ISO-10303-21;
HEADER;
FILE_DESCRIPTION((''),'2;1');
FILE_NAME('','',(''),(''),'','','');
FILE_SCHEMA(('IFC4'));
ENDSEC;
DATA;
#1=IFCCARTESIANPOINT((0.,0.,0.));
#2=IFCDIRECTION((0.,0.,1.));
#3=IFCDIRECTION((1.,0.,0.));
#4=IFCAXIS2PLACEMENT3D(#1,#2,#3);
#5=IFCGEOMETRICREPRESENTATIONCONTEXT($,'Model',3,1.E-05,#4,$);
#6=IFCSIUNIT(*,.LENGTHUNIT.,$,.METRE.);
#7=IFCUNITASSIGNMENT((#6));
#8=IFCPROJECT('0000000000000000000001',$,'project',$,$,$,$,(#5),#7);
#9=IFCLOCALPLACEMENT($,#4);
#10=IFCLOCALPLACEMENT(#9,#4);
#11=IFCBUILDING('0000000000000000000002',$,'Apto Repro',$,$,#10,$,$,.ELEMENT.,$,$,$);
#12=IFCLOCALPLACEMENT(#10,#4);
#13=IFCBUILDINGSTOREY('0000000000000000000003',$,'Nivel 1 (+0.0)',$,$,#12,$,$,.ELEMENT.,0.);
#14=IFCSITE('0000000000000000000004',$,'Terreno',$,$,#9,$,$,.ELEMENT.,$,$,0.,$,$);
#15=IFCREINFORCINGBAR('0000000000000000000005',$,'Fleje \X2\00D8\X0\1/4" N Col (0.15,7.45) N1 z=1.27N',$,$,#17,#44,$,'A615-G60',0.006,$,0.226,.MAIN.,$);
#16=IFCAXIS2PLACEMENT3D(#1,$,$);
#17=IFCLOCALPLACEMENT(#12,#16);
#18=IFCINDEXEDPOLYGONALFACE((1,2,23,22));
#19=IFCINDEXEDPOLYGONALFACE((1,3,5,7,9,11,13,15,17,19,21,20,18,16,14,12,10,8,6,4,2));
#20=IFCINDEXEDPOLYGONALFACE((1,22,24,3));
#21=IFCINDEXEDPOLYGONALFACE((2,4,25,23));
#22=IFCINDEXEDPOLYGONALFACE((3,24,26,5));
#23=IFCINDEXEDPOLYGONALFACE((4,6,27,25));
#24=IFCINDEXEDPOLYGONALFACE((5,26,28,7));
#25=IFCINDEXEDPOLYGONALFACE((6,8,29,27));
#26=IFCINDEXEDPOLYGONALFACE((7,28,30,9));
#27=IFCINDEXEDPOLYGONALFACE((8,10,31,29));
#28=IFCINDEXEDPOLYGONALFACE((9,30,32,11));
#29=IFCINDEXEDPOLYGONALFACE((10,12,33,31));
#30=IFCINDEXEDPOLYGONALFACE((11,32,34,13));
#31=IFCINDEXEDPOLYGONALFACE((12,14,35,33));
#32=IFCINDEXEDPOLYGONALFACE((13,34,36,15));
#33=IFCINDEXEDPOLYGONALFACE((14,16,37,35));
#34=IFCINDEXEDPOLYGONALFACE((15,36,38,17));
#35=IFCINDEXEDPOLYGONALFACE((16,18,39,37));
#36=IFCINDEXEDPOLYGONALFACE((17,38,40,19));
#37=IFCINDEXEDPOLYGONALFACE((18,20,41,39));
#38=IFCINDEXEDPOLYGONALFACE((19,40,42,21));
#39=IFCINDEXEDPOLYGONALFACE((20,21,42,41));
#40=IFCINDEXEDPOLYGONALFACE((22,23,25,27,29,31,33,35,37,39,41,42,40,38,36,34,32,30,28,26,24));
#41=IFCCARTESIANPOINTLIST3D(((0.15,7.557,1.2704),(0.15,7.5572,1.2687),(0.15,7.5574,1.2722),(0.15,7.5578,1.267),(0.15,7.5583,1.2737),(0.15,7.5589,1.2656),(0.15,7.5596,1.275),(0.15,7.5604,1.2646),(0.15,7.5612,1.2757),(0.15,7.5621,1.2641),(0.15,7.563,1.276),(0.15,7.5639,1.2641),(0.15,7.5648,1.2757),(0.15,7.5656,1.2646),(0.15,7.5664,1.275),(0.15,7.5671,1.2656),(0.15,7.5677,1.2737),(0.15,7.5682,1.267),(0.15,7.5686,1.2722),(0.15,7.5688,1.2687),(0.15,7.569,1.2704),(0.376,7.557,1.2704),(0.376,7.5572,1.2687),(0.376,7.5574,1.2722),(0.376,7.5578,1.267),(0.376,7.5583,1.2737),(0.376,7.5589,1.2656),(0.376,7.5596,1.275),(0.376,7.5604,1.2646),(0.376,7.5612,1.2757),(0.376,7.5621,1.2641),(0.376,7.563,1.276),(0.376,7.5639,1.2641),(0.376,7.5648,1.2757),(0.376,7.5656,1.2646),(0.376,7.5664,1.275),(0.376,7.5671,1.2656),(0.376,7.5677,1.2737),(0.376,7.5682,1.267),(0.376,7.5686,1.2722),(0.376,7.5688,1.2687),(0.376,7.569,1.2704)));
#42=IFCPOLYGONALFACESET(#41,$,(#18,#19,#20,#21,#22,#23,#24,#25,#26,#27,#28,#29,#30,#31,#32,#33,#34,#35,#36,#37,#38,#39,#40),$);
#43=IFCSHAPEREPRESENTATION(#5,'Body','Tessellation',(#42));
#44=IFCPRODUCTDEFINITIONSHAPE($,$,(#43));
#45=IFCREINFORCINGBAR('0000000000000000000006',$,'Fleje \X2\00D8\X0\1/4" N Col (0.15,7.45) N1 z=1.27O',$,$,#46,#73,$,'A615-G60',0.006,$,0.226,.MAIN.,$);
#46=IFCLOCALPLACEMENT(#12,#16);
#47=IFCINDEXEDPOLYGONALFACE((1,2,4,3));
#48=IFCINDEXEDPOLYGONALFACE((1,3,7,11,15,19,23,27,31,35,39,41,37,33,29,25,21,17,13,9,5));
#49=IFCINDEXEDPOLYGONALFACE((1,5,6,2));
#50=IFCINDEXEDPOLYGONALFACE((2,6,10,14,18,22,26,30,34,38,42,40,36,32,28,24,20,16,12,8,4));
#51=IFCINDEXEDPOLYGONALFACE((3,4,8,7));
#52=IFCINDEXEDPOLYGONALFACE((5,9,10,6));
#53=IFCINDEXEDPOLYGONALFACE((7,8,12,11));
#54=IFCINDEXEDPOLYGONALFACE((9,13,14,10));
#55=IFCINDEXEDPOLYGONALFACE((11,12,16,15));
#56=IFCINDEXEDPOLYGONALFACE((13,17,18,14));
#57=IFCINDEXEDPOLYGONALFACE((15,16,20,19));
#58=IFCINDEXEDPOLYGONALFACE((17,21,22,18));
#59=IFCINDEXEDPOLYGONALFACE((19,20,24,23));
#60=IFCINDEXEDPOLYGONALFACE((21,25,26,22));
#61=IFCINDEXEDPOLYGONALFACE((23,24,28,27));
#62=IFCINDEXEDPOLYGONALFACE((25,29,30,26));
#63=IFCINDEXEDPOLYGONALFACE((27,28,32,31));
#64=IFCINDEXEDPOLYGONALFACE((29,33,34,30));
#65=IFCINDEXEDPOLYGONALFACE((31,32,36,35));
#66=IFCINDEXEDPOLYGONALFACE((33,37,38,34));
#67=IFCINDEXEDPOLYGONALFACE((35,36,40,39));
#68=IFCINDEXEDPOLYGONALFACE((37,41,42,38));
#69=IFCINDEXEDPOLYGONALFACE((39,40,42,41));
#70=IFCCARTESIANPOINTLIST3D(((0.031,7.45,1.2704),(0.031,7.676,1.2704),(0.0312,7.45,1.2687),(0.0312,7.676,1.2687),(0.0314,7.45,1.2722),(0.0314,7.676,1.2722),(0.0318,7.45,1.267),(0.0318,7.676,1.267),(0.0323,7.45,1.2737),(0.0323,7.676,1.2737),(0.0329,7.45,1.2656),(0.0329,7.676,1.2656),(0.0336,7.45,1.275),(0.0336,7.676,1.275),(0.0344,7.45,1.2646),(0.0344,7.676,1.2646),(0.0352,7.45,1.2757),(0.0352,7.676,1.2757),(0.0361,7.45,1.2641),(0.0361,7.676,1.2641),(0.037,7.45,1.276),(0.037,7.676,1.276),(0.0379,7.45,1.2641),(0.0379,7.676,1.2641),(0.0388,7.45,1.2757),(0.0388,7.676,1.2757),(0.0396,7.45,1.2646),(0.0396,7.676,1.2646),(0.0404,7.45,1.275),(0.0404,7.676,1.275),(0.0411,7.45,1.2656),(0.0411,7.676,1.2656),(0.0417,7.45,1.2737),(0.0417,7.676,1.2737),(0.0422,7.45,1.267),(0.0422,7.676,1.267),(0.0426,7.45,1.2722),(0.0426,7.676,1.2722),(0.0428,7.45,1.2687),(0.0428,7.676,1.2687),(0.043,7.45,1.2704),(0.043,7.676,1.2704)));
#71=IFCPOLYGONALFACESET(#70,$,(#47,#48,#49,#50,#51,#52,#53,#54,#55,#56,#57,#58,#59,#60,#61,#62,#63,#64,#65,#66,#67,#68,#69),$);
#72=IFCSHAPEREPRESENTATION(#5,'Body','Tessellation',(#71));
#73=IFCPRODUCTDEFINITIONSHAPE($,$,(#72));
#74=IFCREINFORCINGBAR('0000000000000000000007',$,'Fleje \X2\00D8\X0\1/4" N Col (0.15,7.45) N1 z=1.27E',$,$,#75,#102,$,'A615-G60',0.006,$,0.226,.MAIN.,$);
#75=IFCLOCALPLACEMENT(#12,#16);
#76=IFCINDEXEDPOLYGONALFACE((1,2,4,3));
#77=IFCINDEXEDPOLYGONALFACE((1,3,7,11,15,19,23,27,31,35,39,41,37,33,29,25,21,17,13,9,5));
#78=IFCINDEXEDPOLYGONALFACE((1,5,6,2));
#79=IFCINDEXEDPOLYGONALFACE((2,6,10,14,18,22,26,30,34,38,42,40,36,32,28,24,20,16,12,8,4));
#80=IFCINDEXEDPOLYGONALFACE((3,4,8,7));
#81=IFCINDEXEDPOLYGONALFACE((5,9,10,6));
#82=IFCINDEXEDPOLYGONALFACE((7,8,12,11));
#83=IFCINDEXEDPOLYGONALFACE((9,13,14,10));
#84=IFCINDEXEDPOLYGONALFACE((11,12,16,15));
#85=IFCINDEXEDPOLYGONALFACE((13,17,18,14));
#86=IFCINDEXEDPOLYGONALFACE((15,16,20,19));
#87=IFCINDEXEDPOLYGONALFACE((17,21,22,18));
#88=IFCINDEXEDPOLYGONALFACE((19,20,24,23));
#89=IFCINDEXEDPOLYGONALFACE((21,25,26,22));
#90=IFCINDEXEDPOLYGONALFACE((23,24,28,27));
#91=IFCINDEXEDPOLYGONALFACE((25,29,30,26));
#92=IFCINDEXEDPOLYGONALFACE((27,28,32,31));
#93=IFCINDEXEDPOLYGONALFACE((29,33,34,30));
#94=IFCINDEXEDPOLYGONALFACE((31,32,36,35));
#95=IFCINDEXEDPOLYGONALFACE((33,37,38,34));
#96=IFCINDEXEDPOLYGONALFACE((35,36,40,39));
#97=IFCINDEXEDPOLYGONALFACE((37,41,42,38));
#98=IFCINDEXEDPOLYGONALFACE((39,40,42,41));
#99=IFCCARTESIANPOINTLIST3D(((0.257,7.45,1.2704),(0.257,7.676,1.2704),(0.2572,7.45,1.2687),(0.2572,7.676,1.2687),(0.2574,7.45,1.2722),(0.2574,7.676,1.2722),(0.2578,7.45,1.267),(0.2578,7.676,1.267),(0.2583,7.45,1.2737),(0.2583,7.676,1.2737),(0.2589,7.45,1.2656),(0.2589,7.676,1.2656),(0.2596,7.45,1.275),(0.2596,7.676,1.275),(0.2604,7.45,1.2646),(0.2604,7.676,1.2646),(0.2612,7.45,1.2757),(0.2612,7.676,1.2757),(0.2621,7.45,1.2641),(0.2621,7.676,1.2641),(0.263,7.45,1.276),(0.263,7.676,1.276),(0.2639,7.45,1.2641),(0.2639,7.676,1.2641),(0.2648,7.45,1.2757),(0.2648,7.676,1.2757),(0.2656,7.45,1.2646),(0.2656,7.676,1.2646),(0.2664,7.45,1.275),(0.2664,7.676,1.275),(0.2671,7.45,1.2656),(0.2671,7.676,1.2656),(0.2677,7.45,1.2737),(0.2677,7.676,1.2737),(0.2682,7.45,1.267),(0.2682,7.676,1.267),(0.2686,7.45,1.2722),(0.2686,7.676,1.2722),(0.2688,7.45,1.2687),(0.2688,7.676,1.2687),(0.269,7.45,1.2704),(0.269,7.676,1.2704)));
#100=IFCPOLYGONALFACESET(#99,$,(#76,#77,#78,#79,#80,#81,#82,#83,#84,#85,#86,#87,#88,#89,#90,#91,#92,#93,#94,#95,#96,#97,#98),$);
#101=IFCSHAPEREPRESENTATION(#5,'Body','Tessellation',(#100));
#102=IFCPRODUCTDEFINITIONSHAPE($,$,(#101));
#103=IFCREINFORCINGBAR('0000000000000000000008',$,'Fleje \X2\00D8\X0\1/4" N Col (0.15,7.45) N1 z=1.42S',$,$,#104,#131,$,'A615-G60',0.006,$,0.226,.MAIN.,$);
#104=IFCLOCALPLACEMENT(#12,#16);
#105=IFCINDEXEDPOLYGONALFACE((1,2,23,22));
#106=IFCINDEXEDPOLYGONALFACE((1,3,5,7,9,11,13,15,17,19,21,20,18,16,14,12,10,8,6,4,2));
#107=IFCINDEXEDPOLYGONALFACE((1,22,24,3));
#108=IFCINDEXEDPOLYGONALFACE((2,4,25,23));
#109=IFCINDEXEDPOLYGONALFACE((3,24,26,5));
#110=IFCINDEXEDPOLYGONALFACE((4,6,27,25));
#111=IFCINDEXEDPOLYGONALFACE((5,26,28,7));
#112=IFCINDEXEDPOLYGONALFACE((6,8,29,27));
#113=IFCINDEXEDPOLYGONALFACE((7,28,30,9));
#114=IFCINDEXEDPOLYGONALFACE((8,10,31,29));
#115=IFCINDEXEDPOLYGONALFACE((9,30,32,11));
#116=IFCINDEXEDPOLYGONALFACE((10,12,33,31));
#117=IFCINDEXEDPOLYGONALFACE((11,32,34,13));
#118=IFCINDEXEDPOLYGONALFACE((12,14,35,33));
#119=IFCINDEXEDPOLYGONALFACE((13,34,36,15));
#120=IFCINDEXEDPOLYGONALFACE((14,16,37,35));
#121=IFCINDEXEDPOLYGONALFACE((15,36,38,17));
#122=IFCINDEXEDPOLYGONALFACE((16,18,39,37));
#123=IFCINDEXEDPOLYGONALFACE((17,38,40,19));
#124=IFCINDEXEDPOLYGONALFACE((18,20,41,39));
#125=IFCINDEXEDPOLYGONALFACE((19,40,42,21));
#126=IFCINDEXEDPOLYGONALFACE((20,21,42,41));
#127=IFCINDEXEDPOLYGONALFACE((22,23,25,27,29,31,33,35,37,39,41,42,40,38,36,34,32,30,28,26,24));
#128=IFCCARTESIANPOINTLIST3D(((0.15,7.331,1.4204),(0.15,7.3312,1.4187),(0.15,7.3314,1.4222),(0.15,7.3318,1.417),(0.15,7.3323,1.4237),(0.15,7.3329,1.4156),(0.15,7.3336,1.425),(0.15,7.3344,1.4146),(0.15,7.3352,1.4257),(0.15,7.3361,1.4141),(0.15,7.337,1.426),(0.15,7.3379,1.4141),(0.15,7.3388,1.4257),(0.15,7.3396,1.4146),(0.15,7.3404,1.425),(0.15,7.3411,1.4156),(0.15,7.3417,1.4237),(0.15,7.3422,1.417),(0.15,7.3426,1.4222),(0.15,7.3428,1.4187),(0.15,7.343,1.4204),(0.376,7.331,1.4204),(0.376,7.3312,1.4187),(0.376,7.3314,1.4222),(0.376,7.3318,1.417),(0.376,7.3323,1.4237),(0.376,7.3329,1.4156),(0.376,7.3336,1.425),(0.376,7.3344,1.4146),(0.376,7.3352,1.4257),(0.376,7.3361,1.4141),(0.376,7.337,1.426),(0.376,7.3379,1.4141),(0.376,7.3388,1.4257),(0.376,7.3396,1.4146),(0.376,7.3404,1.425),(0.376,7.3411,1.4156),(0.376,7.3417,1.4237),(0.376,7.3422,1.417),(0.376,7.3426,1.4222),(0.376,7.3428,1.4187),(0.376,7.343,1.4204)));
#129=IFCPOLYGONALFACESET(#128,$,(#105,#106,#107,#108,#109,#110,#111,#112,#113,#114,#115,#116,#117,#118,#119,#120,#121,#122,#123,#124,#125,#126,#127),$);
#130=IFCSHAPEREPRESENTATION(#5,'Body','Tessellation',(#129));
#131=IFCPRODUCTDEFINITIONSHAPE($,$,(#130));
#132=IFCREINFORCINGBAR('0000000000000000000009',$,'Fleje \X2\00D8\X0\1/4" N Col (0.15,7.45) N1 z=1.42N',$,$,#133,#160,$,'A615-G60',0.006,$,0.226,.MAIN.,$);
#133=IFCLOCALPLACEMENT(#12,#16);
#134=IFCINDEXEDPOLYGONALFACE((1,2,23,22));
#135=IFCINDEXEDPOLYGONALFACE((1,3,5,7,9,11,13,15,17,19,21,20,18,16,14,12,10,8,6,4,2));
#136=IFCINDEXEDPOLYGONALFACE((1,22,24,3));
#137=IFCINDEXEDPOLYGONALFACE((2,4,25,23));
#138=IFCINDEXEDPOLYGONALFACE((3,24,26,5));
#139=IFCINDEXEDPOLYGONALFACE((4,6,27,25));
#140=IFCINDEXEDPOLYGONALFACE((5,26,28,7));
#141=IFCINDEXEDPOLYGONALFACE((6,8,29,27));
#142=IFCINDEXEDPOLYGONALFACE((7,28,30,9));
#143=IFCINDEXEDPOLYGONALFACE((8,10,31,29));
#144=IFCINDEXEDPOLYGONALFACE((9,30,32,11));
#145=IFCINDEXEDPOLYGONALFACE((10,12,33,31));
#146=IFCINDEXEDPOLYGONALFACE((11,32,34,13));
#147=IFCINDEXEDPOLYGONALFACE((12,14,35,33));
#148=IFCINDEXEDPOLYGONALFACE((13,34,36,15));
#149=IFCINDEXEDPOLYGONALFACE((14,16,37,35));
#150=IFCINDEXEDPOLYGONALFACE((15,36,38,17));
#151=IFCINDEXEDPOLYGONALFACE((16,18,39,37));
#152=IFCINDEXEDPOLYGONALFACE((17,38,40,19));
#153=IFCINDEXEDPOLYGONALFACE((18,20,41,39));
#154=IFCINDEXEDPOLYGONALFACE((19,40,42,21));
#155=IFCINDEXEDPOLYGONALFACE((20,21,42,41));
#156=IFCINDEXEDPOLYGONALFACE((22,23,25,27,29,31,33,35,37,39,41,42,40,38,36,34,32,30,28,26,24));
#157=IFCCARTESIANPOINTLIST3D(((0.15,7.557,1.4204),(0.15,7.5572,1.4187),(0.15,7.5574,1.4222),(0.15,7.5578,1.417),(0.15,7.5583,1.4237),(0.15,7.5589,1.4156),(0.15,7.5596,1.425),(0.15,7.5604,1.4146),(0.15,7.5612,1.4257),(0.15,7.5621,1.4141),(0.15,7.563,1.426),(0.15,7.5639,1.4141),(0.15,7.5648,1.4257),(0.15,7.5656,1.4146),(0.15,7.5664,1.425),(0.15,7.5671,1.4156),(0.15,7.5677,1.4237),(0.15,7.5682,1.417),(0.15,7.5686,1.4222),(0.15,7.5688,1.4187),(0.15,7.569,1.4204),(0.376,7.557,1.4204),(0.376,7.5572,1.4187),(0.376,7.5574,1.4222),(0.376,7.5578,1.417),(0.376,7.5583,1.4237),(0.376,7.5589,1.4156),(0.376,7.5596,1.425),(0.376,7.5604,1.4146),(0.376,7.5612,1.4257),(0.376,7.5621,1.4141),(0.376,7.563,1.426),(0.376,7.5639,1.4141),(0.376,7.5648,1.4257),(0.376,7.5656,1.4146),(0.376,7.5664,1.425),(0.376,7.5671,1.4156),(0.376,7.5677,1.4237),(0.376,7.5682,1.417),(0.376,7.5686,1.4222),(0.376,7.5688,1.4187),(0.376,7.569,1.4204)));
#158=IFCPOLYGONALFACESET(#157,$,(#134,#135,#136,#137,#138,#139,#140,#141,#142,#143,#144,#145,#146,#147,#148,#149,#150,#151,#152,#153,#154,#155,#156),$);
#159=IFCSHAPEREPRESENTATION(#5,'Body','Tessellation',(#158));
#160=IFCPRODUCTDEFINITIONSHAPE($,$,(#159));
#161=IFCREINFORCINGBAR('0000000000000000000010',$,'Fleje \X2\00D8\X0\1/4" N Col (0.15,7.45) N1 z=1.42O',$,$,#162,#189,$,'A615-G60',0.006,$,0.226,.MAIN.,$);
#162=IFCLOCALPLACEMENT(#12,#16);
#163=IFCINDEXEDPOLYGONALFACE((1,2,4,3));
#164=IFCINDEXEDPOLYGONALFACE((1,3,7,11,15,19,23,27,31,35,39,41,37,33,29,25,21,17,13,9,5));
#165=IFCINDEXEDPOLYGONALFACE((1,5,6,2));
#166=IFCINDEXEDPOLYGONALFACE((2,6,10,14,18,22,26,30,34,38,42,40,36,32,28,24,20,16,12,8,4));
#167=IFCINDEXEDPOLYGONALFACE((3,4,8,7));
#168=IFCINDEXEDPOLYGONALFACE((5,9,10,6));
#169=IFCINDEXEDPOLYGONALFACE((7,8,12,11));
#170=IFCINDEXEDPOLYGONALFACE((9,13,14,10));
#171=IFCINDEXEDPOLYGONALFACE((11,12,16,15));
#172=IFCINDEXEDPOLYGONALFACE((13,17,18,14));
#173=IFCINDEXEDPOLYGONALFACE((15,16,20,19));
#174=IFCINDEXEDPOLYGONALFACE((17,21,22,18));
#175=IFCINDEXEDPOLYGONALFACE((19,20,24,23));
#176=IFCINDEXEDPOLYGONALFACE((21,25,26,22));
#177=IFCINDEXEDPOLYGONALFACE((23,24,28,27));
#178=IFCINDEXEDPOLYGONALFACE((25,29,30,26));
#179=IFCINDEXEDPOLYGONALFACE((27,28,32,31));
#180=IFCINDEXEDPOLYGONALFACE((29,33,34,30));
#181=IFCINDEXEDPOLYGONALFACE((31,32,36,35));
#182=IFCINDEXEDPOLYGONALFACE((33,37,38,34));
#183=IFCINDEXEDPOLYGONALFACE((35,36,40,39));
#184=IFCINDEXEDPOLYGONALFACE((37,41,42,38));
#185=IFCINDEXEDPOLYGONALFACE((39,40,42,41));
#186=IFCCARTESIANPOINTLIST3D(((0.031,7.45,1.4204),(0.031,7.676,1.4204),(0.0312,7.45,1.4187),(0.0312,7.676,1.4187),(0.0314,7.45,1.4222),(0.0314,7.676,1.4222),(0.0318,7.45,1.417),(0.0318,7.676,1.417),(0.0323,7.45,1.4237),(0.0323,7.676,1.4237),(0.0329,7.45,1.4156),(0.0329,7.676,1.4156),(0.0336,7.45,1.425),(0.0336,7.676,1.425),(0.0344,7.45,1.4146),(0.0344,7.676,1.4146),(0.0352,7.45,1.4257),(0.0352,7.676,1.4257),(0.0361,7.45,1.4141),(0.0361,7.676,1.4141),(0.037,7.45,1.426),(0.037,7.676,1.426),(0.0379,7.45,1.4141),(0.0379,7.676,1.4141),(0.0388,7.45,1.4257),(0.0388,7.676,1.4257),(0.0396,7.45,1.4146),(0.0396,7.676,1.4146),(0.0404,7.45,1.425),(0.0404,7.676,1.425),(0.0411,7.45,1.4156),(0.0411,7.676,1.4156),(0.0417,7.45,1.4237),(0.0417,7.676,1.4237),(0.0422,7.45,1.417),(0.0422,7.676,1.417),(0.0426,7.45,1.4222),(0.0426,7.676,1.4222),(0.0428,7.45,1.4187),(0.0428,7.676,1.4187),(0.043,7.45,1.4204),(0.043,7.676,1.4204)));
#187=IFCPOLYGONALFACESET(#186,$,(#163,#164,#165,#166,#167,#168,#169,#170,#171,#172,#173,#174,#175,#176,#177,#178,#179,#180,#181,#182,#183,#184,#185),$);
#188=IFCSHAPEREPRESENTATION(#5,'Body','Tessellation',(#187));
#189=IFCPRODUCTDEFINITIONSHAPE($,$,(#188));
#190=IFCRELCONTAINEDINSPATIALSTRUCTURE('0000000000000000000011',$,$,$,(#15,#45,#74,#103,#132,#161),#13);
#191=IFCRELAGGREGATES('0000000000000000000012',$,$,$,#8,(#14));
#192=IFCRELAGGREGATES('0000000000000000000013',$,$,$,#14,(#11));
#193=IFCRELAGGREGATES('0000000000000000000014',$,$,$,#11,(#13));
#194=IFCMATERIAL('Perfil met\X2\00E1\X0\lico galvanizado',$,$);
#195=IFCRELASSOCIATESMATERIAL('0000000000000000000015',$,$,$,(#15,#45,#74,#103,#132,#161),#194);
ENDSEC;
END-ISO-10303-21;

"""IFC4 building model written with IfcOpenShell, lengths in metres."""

from ifc_helpers import new_model, si_unit, frame, origin_with_axes, origin_2d_with_axis, place, context, project, spatial, circle, extrude, material, element, save


model = new_model("IFC4")

# Units and contexts
model_context = context("Model", 3, precision=1e-05, world=origin_with_axes())
ifc_project = project(units=[si_unit("LENGTHUNIT", "METRE")], contexts=[model_context])

# Site, building, storey
site_placement = place(None, origin_with_axes())
site = spatial("IfcSite", under=ifc_project, at=site_placement, Name="Terreno", CompositionType="ELEMENT", RefElevation=0.0)
building_placement = place(site_placement, origin_with_axes())
building = spatial("IfcBuilding", under=site, at=building_placement, Name="Apto Repro", CompositionType="ELEMENT")
storey_placement = place(building_placement, origin_with_axes())
storey = spatial("IfcBuildingStorey", under=building, at=storey_placement, Name="Nivel 1 (+0.0)", CompositionType="ELEMENT", Elevation=0.0)

# Reinforcing bars
ifc_material = material(Name="Perfil metálico galvanizado")
reinforcing_bar_1_placement = place(storey_placement, origin_with_axes())
element("IfcReinforcingBar", 1, at=reinforcing_bar_1_placement, inside=storey, material=ifc_material, Name="Fleje Ø1/4\" N Col (0.15,7.45) N1 z=1.27N", SteelGrade="A615-G60", BarLength=0.226, NominalDiameter=0.006, PredefinedType="MAIN", context=model_context, shape_type="SweptSolid", body=[
    extrude(circle(Radius=0.006, at=origin_2d_with_axis()), frame((0.15, 7.563, 1.27), z_axis=(1.0, 0.0, 0.0), x_axis=(0.0, 0.0, 1.0)), (0.0, 0.0, 1.0), 0.226),
])
reinforcing_bar_2_placement = place(storey_placement, origin_with_axes())
element("IfcReinforcingBar", 2, at=reinforcing_bar_2_placement, inside=storey, material=ifc_material, Name="Fleje Ø1/4\" N Col (0.15,7.45) N1 z=1.27O", SteelGrade="A615-G60", BarLength=0.226, NominalDiameter=0.006, PredefinedType="MAIN", context=model_context, shape_type="SweptSolid", body=[
    extrude(circle(Radius=0.006, at=origin_2d_with_axis()), frame((0.037, 7.45, 1.27), z_axis=(0.0, 1.0, 0.0), x_axis=(0.0, 0.0, 1.0)), (0.0, 0.0, 1.0), 0.226),
])
reinforcing_bar_3_placement = place(storey_placement, origin_with_axes())
element("IfcReinforcingBar", 3, at=reinforcing_bar_3_placement, inside=storey, material=ifc_material, Name="Fleje Ø1/4\" N Col (0.15,7.45) N1 z=1.27E", SteelGrade="A615-G60", BarLength=0.226, NominalDiameter=0.006, PredefinedType="MAIN", context=model_context, shape_type="SweptSolid", body=[
    extrude(circle(Radius=0.006, at=origin_2d_with_axis()), frame((0.263, 7.45, 1.27), z_axis=(0.0, 1.0, 0.0), x_axis=(0.0, 0.0, 1.0)), (0.0, 0.0, 1.0), 0.226),
])
reinforcing_bar_4_placement = place(storey_placement, origin_with_axes())
element("IfcReinforcingBar", 4, at=reinforcing_bar_4_placement, inside=storey, material=ifc_material, Name="Fleje Ø1/4\" N Col (0.15,7.45) N1 z=1.42S", SteelGrade="A615-G60", BarLength=0.226, NominalDiameter=0.006, PredefinedType="MAIN", context=model_context, shape_type="SweptSolid", body=[
    extrude(circle(Radius=0.006, at=origin_2d_with_axis()), frame((0.15, 7.337, 1.42), z_axis=(1.0, 0.0, 0.0), x_axis=(0.0, 0.0, 1.0)), (0.0, 0.0, 1.0), 0.226),
])
reinforcing_bar_5_placement = place(storey_placement, origin_with_axes())
element("IfcReinforcingBar", 5, at=reinforcing_bar_5_placement, inside=storey, material=ifc_material, Name="Fleje Ø1/4\" N Col (0.15,7.45) N1 z=1.42N", SteelGrade="A615-G60", BarLength=0.226, NominalDiameter=0.006, PredefinedType="MAIN", context=model_context, shape_type="SweptSolid", body=[
    extrude(circle(Radius=0.006, at=origin_2d_with_axis()), frame((0.15, 7.563, 1.42), z_axis=(1.0, 0.0, 0.0), x_axis=(0.0, 0.0, 1.0)), (0.0, 0.0, 1.0), 0.226),
])
reinforcing_bar_6_placement = place(storey_placement, origin_with_axes())
element("IfcReinforcingBar", 6, at=reinforcing_bar_6_placement, inside=storey, material=ifc_material, Name="Fleje Ø1/4\" N Col (0.15,7.45) N1 z=1.42O", SteelGrade="A615-G60", BarLength=0.226, NominalDiameter=0.006, PredefinedType="MAIN", context=model_context, shape_type="SweptSolid", body=[
    extrude(circle(Radius=0.006, at=origin_2d_with_axis()), frame((0.037, 7.45, 1.42), z_axis=(0.0, 1.0, 0.0), x_axis=(0.0, 0.0, 1.0)), (0.0, 0.0, 1.0), 0.226),
])

save(model, "model.ifc")
